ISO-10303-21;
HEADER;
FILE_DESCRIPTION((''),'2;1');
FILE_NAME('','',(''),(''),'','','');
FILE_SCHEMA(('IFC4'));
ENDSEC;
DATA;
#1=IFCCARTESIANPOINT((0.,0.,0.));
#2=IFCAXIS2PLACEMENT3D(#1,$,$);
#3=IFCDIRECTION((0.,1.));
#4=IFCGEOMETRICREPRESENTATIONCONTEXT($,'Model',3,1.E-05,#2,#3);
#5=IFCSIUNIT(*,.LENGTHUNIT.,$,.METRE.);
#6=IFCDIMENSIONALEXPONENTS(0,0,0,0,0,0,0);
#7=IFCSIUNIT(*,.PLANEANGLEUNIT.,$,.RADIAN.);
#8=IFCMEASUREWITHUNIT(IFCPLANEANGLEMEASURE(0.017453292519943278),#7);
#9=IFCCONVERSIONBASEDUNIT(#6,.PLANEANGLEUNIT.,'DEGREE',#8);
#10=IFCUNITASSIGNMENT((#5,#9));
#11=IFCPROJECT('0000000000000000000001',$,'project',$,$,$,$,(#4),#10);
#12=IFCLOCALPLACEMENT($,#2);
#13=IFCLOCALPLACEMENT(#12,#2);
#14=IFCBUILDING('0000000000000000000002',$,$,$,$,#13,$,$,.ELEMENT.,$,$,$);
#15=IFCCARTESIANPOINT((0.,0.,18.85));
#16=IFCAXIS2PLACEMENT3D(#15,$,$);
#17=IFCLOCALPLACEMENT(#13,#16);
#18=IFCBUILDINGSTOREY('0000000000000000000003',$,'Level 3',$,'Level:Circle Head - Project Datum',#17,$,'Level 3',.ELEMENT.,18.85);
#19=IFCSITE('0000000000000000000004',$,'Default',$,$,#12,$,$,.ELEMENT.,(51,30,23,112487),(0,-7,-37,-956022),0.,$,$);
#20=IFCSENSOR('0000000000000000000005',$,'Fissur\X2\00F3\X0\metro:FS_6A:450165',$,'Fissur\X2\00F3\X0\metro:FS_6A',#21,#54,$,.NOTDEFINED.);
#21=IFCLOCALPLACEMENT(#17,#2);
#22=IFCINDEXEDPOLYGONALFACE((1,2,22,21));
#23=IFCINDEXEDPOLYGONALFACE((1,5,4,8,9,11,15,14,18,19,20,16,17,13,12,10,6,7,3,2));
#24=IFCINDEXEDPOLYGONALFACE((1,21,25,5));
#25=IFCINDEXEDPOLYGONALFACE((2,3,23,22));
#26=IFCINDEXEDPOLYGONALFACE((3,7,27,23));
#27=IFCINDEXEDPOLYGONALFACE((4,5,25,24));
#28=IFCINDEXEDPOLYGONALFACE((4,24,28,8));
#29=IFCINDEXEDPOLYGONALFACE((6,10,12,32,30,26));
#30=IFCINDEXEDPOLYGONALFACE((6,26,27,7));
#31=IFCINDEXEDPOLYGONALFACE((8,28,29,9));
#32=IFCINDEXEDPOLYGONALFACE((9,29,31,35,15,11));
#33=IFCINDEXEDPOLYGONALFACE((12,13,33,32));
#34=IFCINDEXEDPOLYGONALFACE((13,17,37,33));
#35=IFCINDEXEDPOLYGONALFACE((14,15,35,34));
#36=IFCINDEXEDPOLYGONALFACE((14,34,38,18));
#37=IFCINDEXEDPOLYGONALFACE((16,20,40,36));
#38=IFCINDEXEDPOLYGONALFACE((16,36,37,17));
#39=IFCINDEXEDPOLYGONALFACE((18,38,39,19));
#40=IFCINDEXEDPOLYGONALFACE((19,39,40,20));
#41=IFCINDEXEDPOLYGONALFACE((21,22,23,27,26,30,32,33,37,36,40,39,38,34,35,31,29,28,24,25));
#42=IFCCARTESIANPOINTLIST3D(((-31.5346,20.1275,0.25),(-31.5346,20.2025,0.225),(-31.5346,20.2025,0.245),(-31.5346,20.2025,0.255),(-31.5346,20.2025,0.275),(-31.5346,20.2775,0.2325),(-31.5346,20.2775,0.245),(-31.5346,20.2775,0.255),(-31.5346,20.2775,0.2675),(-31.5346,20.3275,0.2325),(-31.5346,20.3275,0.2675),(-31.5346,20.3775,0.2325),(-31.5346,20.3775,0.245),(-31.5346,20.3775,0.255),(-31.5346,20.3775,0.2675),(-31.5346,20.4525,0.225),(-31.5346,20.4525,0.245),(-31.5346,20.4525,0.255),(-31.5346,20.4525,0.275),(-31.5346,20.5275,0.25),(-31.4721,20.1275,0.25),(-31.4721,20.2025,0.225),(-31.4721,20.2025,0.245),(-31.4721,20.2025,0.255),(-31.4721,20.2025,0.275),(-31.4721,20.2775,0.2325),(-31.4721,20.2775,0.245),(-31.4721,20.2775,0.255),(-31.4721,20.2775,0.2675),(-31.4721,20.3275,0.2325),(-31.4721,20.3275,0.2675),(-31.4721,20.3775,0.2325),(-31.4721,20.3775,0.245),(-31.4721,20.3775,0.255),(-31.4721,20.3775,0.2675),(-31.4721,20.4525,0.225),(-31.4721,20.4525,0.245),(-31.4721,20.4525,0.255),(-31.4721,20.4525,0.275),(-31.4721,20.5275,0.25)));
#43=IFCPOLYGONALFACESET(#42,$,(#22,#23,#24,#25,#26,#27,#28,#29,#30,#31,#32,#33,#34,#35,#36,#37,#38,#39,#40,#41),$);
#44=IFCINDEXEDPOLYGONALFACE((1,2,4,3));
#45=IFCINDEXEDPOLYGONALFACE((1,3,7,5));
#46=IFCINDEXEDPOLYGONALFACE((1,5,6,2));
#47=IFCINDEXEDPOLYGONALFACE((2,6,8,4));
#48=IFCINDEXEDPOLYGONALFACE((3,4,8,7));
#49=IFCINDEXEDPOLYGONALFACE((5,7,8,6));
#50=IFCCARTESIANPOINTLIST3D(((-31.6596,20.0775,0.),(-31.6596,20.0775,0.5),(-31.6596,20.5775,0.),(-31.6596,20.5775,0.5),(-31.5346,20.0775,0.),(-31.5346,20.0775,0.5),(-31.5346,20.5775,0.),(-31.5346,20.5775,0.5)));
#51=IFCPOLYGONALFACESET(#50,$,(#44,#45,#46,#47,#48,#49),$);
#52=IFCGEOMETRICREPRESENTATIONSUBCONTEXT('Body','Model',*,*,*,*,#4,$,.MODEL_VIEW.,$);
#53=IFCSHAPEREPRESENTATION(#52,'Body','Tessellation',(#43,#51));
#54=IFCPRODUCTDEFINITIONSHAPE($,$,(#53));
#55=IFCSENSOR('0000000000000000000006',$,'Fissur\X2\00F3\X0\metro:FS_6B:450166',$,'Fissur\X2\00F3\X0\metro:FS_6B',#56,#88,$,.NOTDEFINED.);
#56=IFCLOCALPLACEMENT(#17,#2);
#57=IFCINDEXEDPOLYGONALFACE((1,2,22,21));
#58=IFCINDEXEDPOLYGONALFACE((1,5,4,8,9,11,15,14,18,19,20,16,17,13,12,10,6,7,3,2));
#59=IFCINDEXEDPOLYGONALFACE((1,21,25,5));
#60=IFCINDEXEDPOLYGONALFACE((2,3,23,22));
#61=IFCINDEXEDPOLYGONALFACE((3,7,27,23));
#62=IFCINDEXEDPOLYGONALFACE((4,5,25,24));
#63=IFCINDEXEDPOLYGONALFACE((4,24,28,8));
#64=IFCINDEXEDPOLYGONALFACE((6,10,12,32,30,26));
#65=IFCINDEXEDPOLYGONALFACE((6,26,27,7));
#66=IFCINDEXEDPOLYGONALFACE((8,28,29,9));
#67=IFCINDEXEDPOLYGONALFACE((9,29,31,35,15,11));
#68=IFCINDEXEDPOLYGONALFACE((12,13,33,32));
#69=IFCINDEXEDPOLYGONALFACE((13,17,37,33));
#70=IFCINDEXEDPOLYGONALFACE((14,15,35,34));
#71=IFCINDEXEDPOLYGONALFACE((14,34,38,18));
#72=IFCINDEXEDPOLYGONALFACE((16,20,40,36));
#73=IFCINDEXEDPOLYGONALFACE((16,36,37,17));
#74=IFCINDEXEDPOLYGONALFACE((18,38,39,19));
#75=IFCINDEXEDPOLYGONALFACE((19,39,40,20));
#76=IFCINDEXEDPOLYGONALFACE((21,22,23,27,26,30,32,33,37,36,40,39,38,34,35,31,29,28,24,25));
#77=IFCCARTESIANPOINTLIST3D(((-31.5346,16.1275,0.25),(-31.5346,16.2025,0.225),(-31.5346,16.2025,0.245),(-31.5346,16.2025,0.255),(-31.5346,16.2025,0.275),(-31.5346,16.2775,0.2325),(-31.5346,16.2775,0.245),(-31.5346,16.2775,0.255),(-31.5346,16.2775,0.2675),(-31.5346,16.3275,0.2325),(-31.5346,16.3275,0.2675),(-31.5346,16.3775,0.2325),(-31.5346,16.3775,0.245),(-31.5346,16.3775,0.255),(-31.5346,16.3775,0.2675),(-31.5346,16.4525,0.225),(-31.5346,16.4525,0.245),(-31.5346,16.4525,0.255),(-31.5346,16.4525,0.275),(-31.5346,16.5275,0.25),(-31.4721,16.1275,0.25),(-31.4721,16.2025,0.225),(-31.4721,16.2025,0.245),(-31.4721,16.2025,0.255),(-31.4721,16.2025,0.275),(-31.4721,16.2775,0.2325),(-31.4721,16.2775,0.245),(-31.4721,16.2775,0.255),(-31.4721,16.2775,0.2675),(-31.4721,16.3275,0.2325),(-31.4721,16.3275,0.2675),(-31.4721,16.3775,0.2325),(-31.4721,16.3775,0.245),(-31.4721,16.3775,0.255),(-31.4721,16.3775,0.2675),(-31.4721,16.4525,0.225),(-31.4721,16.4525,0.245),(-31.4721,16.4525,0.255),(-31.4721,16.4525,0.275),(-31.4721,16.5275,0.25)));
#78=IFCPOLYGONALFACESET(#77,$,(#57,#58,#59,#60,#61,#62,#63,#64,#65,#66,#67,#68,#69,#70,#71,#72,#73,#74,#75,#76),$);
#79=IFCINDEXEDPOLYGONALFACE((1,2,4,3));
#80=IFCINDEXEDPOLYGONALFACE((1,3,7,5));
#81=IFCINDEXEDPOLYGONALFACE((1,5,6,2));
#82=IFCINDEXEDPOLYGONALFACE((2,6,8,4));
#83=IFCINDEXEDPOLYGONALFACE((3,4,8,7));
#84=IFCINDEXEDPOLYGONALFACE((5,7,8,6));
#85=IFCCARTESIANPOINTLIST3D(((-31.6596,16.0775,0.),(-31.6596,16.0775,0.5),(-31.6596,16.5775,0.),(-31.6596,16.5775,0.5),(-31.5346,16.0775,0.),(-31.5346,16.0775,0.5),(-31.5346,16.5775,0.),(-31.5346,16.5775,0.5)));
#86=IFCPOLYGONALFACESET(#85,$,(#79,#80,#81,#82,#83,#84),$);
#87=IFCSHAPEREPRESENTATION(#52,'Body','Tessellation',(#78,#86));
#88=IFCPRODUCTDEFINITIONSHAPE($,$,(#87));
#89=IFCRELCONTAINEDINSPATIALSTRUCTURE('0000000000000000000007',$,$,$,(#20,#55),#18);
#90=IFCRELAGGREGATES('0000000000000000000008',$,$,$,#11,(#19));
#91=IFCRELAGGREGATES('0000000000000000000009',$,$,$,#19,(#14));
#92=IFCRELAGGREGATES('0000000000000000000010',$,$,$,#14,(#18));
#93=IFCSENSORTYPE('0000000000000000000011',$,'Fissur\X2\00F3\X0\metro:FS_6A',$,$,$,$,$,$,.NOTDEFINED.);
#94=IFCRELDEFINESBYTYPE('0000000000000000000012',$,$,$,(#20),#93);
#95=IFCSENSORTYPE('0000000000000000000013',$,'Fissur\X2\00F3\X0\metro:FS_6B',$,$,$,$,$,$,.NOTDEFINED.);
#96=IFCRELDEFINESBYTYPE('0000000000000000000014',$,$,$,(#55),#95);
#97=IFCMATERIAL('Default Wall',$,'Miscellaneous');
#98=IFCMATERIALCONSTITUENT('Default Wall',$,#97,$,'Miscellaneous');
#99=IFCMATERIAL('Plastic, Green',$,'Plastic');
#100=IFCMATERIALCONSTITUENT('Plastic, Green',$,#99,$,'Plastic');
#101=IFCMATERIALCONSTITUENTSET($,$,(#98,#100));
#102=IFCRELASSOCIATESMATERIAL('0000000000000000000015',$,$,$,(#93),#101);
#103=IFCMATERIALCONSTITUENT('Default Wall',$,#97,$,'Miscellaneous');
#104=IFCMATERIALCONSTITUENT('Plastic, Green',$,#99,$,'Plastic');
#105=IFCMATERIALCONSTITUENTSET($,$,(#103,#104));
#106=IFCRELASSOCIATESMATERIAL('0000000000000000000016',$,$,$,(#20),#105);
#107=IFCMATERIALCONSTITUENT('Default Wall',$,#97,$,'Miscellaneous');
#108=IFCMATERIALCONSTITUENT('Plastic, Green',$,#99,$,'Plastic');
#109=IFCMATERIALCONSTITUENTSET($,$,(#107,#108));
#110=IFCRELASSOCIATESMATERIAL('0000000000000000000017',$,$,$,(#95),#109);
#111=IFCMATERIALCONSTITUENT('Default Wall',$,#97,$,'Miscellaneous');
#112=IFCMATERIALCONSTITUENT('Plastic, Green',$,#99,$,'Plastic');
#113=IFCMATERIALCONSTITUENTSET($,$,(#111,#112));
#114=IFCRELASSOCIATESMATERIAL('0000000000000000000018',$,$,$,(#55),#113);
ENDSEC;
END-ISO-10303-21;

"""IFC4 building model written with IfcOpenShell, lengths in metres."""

from ifc_helpers import new_model, entity, si_unit, converted_unit, direction, frame, origin, place, context, subcontext, project, spatial, indexed_curve, outline, extrude, source, transform, mapped, material, constituent, constituent_set, type_object, type_shapes, element, save


model = new_model("IFC4")

# Units and contexts
model_context = context("Model", 3, precision=1e-05, world=origin(), true_north=direction((0.0, 1.0)))
body_context = subcontext(model_context, "Body", "Model", "MODEL_VIEW")
ifc_project = project(units=[si_unit("LENGTHUNIT", "METRE"), converted_unit("PLANEANGLEUNIT", "DEGREE", entity("IfcPlaneAngleMeasure", 0.017453292519943278), si_unit("PLANEANGLEUNIT", "RADIAN"), dimensions=[0, 0, 0, 0, 0, 0, 0])], contexts=[model_context])

# Site, building, storey
site_placement = place(None, origin())
site = spatial("IfcSite", under=ifc_project, at=site_placement, Name="Default", CompositionType="ELEMENT", RefLatitude=(51, 30, 23, 112487), RefLongitude=(0, -7, -37, -956022), RefElevation=0.0)
building_placement = place(site_placement, origin())
building = spatial("IfcBuilding", under=site, at=building_placement, CompositionType="ELEMENT")
storey_placement = place(building_placement, frame((0.0, 0.0, 18.85)))
storey = spatial("IfcBuildingStorey", under=building, at=storey_placement, Name="Level 3", ObjectType="Level:Circle Head - Project Datum", LongName="Level 3", CompositionType="ELEMENT", Elevation=18.85)

# Sensors
ifc_material_1 = material(Name="Default Wall", Category="Miscellaneous")
ifc_material_2 = material(Name="Plastic, Green", Category="Plastic")
ifc_constituent_1 = constituent(ifc_material_1, Name="Default Wall", Category="Miscellaneous")
ifc_constituent_2 = constituent(ifc_material_2, Name="Plastic, Green", Category="Plastic")
ifc_constituent_set_1 = constituent_set(constituents=[ifc_constituent_1, ifc_constituent_2])
ifc_constituent_3 = constituent(ifc_material_1, Name="Default Wall", Category="Miscellaneous")
ifc_constituent_4 = constituent(ifc_material_2, Name="Plastic, Green", Category="Plastic")
ifc_constituent_set_2 = constituent_set(constituents=[ifc_constituent_3, ifc_constituent_4])
sensor_type_1 = type_object("IfcSensorType", Name="Fissurómetro:FS_6A", PredefinedType="NOTDEFINED", material=ifc_constituent_set_2)
shared_shape_1 = source(origin(), body_context, "Body", "SweptSolid", [
    extrude(outline(indexed_curve([(-0.025, -0.125), (0.0, -0.2), (0.025, -0.125), (0.005, -0.125), (0.005, -0.05), (0.0175, -0.05), (0.0175, 0.0), (0.0175, 0.05), (0.005, 0.05), (0.005, 0.125), (0.025, 0.125), (0.0, 0.2), (-0.025, 0.125), (-0.005, 0.125), (-0.005, 0.05), (-0.0175, 0.05), (-0.0175, 0.0), (-0.0175, -0.05), (-0.005, -0.05), (-0.005, -0.125), (-0.025, -0.125)], self_intersect=False)), frame((0.0, 0.0625, 0.25), z_axis=(0.0, -1.0, 0.0), x_axis=(0.0, 0.0, -1.0)), (0.0, 0.0, -1.0), 0.0625),
    extrude(outline(indexed_curve([(-0.0625, -0.25), (0.0625, -0.25), (0.0625, 0.25), (-0.0625, 0.25), (-0.0625, -0.25)], self_intersect=False)), frame((0.0, 0.0, 0.0), z_axis=(0.0, 0.0, 1.0), x_axis=(0.0, 1.0, 0.0)), (0.0, 0.0, 1.0), 0.5),
])
type_shapes(sensor_type_1, [shared_shape_1])
sensor_1_placement = place(storey_placement, frame((-31.5971, 20.3275, 0.0), z_axis=(0.0, 0.0, 1.0), x_axis=(0.0, -1.0, 0.0)))
element("IfcSensor", 1, at=sensor_1_placement, inside=storey, type_object=sensor_type_1, material=ifc_constituent_set_1, Name="Fissurómetro:FS_6A:450165", ObjectType="Fissurómetro:FS_6A", PredefinedType="NOTDEFINED", context=body_context, shape_type="MappedRepresentation", body=[
    mapped(shared_shape_1, transform((0.0, 0.0, 0.0), scale=1.0)),
])
ifc_constituent_5 = constituent(ifc_material_1, Name="Default Wall", Category="Miscellaneous")
ifc_constituent_6 = constituent(ifc_material_2, Name="Plastic, Green", Category="Plastic")
ifc_constituent_set_3 = constituent_set(constituents=[ifc_constituent_5, ifc_constituent_6])
ifc_constituent_7 = constituent(ifc_material_1, Name="Default Wall", Category="Miscellaneous")
ifc_constituent_8 = constituent(ifc_material_2, Name="Plastic, Green", Category="Plastic")
ifc_constituent_set_4 = constituent_set(constituents=[ifc_constituent_7, ifc_constituent_8])
sensor_type_2 = type_object("IfcSensorType", Name="Fissurómetro:FS_6B", PredefinedType="NOTDEFINED", material=ifc_constituent_set_4)
shared_shape_2 = source(origin(), body_context, "Body", "SweptSolid", [
    extrude(outline(indexed_curve([(-0.025, -0.125), (0.0, -0.2), (0.025, -0.125), (0.005, -0.125), (0.005, -0.05), (0.0175, -0.05), (0.0175, 0.0), (0.0175, 0.05), (0.005, 0.05), (0.005, 0.125), (0.025, 0.125), (0.0, 0.2), (-0.025, 0.125), (-0.005, 0.125), (-0.005, 0.05), (-0.0175, 0.05), (-0.0175, 0.0), (-0.0175, -0.05), (-0.005, -0.05), (-0.005, -0.125), (-0.025, -0.125)], self_intersect=False)), frame((0.0, 0.0625, 0.25), z_axis=(0.0, -1.0, 0.0), x_axis=(0.0, 0.0, -1.0)), (0.0, 0.0, -1.0), 0.0625),
    extrude(outline(indexed_curve([(-0.0625, -0.25), (0.0625, -0.25), (0.0625, 0.25), (-0.0625, 0.25), (-0.0625, -0.25)], self_intersect=False)), frame((0.0, 0.0, 0.0), z_axis=(0.0, 0.0, 1.0), x_axis=(0.0, 1.0, 0.0)), (0.0, 0.0, 1.0), 0.5),
])
type_shapes(sensor_type_2, [shared_shape_2])
sensor_2_placement = place(storey_placement, frame((-31.5971, 16.3275, 0.0), z_axis=(0.0, 0.0, 1.0), x_axis=(0.0, -1.0, 0.0)))
element("IfcSensor", 2, at=sensor_2_placement, inside=storey, type_object=sensor_type_2, material=ifc_constituent_set_3, Name="Fissurómetro:FS_6B:450166", ObjectType="Fissurómetro:FS_6B", PredefinedType="NOTDEFINED", context=body_context, shape_type="MappedRepresentation", body=[
    mapped(shared_shape_2, transform((0.0, 0.0, 0.0), scale=1.0)),
])

save(model, "model.ifc")
